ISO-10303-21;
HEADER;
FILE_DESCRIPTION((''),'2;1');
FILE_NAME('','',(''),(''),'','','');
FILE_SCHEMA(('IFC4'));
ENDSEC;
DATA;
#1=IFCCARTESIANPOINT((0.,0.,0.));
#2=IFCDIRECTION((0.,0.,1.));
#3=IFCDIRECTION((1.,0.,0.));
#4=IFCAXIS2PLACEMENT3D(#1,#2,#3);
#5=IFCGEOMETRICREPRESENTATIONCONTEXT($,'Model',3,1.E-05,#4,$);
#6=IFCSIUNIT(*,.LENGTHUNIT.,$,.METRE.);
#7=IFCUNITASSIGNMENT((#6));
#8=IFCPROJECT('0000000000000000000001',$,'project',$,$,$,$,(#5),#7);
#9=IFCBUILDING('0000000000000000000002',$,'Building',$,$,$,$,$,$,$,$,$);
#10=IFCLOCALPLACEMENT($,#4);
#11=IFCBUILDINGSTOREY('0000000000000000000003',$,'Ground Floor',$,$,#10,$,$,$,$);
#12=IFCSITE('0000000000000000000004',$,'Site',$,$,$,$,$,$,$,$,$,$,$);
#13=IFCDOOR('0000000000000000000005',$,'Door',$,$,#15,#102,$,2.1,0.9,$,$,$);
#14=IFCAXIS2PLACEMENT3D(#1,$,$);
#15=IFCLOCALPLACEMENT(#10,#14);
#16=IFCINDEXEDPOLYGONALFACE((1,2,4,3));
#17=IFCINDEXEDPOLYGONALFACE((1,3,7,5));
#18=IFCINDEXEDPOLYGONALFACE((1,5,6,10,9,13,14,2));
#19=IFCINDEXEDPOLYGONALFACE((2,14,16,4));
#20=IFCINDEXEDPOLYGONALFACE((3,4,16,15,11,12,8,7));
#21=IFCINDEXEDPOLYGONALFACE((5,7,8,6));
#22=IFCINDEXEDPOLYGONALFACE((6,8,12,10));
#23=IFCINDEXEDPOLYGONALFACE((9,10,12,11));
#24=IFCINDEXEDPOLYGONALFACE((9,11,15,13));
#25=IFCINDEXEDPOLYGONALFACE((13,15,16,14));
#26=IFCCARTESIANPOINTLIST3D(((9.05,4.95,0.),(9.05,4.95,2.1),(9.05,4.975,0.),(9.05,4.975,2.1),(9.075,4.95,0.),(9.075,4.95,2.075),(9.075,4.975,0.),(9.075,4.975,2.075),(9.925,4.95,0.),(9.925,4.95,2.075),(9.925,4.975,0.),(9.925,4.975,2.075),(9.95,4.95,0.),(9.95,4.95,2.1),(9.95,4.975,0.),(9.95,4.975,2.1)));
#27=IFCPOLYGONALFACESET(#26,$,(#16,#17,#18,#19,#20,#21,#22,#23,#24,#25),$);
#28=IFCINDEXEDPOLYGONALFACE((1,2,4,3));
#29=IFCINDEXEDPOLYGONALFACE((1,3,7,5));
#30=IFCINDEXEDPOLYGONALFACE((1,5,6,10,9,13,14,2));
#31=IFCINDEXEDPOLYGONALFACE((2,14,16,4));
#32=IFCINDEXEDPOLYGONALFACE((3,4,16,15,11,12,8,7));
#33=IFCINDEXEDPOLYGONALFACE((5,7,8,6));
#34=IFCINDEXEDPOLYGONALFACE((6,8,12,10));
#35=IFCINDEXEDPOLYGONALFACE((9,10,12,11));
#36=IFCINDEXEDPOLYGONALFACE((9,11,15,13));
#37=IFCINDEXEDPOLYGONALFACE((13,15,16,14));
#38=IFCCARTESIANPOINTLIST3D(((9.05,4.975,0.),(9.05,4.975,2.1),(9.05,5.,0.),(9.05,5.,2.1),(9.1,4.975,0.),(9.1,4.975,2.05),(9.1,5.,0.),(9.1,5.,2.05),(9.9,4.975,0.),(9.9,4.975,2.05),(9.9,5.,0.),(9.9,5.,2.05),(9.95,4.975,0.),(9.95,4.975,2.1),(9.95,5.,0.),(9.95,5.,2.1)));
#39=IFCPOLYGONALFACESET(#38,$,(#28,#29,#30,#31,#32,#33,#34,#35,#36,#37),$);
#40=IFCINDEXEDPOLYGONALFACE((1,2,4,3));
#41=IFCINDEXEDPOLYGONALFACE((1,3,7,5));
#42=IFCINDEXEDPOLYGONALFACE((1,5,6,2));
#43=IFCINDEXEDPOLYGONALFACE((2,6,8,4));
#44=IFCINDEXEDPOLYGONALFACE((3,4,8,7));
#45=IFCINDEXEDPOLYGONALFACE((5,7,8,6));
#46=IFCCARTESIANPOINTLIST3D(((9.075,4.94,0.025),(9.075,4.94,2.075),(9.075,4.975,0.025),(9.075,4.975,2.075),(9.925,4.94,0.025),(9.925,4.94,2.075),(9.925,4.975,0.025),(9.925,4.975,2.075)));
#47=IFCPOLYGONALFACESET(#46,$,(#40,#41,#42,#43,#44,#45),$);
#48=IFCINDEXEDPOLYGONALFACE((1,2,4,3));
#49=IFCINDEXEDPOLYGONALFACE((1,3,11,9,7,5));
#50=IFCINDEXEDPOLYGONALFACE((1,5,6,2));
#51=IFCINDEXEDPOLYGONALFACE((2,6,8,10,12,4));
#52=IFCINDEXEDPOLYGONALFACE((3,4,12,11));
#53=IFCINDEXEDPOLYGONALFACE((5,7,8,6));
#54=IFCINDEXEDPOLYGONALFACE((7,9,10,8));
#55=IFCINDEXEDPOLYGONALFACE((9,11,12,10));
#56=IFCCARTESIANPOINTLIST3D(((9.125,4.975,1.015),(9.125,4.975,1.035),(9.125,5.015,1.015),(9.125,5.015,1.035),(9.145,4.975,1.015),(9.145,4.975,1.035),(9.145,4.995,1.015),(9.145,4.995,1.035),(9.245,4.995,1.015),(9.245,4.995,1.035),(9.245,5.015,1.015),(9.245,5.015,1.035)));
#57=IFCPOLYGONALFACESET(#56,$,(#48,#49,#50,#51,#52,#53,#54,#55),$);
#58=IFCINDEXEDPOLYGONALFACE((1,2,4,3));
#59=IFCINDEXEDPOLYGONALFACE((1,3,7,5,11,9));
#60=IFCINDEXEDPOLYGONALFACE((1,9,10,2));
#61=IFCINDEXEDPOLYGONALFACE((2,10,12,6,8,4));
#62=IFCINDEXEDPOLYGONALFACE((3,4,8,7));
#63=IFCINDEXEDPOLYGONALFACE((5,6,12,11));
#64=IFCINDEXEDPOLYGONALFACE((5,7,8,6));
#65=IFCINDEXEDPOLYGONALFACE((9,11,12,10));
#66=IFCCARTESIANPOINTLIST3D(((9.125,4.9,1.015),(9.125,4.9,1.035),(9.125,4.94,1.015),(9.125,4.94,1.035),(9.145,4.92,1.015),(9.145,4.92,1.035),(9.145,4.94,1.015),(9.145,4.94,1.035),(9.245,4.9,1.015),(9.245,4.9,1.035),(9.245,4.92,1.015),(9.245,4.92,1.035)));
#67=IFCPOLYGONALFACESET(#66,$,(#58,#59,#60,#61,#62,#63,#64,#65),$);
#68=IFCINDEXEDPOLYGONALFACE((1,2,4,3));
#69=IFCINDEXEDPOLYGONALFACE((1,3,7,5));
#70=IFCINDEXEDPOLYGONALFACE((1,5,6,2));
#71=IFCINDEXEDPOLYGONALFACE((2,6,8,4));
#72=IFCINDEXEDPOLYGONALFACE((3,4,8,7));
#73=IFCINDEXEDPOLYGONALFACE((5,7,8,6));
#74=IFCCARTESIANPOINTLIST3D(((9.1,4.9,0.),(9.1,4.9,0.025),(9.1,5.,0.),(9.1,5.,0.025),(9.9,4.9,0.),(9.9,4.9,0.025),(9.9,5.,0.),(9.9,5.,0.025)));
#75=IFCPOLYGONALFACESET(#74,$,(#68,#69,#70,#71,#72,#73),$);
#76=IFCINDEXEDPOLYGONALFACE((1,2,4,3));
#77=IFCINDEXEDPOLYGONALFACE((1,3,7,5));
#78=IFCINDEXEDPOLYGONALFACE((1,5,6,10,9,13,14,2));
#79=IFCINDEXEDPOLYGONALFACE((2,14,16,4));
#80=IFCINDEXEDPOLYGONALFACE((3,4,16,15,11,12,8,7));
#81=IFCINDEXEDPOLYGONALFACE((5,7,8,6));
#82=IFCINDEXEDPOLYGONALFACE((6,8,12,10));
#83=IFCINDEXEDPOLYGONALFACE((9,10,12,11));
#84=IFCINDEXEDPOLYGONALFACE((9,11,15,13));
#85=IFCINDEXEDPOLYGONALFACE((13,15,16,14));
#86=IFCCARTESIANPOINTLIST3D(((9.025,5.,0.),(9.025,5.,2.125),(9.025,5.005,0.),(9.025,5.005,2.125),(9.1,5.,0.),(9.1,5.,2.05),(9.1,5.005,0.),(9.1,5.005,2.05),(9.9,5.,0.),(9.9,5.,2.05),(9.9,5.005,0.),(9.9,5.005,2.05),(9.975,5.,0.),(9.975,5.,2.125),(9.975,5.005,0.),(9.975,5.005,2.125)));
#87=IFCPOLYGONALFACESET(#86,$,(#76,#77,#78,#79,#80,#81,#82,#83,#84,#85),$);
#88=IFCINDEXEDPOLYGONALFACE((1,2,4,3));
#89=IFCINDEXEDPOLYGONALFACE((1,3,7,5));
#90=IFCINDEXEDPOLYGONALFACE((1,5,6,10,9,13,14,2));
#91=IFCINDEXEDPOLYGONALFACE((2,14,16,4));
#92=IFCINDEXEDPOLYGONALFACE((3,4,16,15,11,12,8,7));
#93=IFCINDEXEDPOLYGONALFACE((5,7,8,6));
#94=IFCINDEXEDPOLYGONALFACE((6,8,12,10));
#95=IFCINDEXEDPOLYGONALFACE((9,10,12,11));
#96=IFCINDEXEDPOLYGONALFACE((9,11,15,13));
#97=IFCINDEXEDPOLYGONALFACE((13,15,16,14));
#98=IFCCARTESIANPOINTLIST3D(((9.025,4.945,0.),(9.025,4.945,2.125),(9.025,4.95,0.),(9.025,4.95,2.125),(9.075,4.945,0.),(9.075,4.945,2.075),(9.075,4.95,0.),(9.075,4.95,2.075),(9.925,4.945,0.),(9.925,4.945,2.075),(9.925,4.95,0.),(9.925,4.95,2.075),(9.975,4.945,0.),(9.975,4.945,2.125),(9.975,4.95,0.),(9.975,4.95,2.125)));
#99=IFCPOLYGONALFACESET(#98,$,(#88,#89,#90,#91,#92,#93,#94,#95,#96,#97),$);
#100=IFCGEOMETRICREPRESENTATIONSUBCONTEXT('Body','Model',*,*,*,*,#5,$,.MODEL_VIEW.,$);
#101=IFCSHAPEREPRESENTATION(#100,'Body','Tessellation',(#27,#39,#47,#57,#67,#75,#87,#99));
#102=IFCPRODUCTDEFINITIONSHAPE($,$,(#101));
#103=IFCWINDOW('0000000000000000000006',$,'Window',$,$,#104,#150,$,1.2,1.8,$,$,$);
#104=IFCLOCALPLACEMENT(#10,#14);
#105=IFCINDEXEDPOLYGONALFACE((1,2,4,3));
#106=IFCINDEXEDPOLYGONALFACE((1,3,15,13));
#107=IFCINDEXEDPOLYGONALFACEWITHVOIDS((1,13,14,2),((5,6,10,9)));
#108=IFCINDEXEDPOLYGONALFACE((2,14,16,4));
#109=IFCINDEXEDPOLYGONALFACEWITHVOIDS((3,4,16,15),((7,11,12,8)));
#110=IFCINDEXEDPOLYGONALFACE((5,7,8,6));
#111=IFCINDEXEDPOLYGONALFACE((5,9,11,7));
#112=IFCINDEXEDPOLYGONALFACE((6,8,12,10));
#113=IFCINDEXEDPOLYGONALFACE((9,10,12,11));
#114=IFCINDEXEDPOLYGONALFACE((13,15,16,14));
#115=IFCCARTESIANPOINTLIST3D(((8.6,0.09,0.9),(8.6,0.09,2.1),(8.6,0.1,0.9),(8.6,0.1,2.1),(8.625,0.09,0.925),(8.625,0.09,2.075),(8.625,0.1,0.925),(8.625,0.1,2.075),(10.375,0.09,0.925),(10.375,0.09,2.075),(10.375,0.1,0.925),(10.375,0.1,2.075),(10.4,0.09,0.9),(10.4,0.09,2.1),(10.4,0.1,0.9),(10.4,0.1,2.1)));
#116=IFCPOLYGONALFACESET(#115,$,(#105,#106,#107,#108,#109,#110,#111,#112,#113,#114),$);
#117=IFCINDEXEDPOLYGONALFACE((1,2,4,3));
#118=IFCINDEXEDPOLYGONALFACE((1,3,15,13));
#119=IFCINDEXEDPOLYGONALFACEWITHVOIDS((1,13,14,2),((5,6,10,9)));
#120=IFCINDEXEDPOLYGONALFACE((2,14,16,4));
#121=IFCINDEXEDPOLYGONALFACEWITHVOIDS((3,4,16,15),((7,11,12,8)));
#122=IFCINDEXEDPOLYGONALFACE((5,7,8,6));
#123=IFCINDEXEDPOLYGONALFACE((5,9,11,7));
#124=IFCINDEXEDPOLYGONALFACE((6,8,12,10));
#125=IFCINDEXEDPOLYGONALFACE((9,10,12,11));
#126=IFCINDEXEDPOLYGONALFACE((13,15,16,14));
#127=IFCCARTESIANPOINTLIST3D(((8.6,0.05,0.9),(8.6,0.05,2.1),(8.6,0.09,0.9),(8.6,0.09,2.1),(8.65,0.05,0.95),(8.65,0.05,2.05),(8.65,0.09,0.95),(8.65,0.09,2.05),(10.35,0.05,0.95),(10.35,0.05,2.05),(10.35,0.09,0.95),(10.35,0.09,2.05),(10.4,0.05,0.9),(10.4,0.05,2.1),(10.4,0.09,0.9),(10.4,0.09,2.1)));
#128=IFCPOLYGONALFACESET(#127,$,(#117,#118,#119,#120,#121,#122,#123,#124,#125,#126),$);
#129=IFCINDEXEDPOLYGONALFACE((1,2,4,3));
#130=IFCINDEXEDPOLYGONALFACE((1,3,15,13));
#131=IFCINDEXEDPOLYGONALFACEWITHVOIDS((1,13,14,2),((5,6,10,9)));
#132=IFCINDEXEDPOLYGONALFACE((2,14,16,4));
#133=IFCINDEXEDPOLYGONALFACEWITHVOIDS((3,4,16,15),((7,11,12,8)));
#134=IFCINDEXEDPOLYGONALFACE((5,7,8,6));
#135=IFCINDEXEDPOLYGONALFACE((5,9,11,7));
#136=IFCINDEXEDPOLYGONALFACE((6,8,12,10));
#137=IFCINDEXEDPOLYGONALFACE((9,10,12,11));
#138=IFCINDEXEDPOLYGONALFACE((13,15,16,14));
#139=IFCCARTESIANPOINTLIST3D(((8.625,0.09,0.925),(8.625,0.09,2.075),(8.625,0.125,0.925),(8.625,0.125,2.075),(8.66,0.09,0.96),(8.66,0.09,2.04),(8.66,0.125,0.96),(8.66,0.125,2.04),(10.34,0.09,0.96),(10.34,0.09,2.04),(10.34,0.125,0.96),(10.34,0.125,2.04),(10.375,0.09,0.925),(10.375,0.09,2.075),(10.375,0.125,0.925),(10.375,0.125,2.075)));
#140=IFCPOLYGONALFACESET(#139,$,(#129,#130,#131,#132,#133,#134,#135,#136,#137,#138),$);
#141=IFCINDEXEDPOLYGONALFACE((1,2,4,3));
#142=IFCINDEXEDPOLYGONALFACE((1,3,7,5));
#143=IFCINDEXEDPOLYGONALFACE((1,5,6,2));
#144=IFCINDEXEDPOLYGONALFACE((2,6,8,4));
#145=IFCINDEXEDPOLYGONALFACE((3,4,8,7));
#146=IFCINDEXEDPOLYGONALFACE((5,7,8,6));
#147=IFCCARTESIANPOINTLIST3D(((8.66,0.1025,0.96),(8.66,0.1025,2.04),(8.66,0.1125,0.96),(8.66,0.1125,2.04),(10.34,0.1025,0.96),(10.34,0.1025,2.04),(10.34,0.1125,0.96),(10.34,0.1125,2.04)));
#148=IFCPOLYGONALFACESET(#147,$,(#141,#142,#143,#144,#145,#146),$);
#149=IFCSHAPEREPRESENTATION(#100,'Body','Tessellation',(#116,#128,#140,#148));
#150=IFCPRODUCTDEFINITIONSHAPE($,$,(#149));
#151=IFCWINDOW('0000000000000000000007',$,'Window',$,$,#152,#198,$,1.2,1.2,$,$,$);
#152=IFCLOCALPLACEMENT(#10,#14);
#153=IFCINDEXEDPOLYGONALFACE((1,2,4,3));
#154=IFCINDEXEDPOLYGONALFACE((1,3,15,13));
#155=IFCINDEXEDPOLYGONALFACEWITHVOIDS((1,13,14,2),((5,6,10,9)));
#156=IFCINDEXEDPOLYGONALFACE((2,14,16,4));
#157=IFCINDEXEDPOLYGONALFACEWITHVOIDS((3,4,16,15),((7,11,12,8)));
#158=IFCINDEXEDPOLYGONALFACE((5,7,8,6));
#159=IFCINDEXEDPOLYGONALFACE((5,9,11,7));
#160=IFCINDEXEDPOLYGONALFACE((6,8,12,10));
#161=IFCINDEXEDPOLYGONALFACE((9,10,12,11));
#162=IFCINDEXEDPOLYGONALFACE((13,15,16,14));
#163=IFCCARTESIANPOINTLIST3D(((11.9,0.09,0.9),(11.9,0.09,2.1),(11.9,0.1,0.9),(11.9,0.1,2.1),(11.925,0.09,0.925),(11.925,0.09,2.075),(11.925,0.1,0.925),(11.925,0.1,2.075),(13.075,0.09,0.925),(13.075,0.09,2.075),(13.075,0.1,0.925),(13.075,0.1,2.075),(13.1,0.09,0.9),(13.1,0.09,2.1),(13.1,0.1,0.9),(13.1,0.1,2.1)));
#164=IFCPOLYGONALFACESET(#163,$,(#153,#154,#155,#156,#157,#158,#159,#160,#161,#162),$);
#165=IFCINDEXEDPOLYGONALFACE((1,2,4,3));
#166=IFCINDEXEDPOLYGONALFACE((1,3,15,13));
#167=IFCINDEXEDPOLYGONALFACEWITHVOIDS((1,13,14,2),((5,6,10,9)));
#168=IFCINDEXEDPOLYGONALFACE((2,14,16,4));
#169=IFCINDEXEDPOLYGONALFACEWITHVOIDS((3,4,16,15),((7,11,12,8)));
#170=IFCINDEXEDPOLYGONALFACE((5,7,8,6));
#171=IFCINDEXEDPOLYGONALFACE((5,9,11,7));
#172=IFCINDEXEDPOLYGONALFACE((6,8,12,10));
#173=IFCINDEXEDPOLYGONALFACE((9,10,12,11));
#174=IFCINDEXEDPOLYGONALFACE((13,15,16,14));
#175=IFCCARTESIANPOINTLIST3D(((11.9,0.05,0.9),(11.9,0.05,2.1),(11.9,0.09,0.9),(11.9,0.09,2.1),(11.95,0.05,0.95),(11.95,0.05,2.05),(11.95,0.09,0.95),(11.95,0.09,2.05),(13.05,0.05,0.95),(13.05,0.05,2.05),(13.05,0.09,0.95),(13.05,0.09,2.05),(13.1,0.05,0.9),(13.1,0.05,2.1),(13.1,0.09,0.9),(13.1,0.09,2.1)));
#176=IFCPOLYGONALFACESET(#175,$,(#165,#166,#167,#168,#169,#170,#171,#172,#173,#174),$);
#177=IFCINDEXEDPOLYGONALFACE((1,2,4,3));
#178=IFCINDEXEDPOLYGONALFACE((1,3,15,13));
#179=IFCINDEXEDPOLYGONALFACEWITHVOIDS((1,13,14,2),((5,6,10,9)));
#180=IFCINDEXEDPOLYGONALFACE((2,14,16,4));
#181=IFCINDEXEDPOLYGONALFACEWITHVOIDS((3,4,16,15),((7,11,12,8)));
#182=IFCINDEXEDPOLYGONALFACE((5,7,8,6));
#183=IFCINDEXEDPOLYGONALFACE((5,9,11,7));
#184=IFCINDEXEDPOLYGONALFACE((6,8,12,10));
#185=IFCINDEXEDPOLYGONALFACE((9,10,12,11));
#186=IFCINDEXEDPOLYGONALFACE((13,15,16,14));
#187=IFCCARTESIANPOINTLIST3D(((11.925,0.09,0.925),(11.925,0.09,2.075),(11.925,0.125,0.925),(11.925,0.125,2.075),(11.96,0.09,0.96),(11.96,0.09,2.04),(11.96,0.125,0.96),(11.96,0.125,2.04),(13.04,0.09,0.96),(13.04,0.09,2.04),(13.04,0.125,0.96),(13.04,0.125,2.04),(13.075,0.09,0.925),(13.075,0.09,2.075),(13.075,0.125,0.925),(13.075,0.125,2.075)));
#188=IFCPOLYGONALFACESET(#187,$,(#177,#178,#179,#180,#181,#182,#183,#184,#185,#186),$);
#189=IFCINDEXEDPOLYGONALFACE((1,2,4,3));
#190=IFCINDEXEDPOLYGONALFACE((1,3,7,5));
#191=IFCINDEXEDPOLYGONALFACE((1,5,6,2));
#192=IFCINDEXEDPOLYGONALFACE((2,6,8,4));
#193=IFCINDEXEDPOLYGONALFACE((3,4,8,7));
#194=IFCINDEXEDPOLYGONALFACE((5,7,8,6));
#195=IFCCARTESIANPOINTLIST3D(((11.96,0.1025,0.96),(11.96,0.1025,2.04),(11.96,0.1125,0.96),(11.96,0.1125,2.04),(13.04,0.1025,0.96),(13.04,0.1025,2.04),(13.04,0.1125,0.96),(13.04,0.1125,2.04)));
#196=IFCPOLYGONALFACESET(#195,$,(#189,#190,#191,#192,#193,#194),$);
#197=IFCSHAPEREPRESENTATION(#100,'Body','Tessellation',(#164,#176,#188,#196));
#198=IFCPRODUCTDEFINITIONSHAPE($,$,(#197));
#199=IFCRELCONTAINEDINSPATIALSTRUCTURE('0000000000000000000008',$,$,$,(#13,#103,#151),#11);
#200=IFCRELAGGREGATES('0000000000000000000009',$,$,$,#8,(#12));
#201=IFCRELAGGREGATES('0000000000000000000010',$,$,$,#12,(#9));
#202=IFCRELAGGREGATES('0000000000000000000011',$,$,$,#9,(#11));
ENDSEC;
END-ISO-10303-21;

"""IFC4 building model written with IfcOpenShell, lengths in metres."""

from ifc_helpers import new_model, si_unit, frame, origin_with_axes, place, context, subcontext, project, spatial, line, indexed_curve, outline, extrude, element, save


model = new_model("IFC4")

# Units and contexts
model_context = context("Model", 3, precision=1e-05, world=origin_with_axes())
body_context = subcontext(model_context, "Body", "Model", "MODEL_VIEW")
ifc_project = project(units=[si_unit("LENGTHUNIT", "METRE")], contexts=[model_context])

# Site, building, storey
site = spatial("IfcSite", under=ifc_project, Name="Site")
building = spatial("IfcBuilding", under=site, Name="Building")
storey_placement = place(None, origin_with_axes())
storey = spatial("IfcBuildingStorey", under=building, at=storey_placement, Name="Ground Floor")

# Door
door_1_placement = place(storey_placement, frame((9.95, 5.0, 0.0), z_axis=(0.0, 0.0, 1.0), x_axis=(-1.0, 0.0, 0.0)))
element("IfcDoor", 1, at=door_1_placement, inside=storey, Name="Door", OverallHeight=2.1, OverallWidth=0.9, context=body_context, shape_type="SweptSolid", body=[
    extrude(outline(indexed_curve([(0.0, 0.0), (0.0, 2.1), (0.9, 2.1), (0.9, 0.0), (0.875, 0.0), (0.875, 2.075), (0.025, 2.075), (0.025, 0.0)], segments=[line(1, 2, 3, 4, 5, 6, 7, 8, 1)])), frame((0.0, 0.025, 0.0), z_axis=(0.0, -1.0, 0.0), x_axis=(1.0, 0.0, 0.0)), (0.0, 0.0, -1.0), 0.025),
    extrude(outline(indexed_curve([(0.0, 0.0), (0.0, 2.1), (0.9, 2.1), (0.9, 0.0), (0.85, 0.0), (0.85, 2.05), (0.05, 2.05), (0.05, 0.0)], segments=[line(1, 2, 3, 4, 5, 6, 7, 8, 1)])), frame((0.0, 0.0, 0.0), z_axis=(0.0, -1.0, 0.0), x_axis=(1.0, 0.0, 0.0)), (0.0, 0.0, -1.0), 0.025),
    extrude(outline(indexed_curve([(0.0, 0.0), (0.85, 0.0), (0.85, 0.035), (0.0, 0.035)], segments=[line(1, 2, 3, 4, 1)])), frame((0.025, 0.025, 0.025), z_axis=(0.0, 0.0, 1.0), x_axis=(1.0, 0.0, 0.0)), (0.0, 0.0, 1.0), 2.05),
    extrude(outline(indexed_curve([(0.0, 0.0), (0.0, -0.04), (-0.12, -0.04), (-0.12, -0.02), (-0.02, -0.02), (-0.02, 0.0)], segments=[line(1, 2, 3, 4, 5, 6, 1)])), frame((0.825, 0.025, 1.015), z_axis=(0.0, 0.0, 1.0), x_axis=(1.0, 0.0, 0.0)), (0.0, 0.0, 1.0), 0.02),
    extrude(outline(indexed_curve([(0.0, 0.0), (0.0, 0.04), (-0.12, 0.04), (-0.12, 0.02), (-0.02, 0.02), (-0.02, 0.0)], segments=[line(1, 2, 3, 4, 5, 6, 1)])), frame((0.825, 0.06, 1.015), z_axis=(0.0, 0.0, 1.0), x_axis=(1.0, 0.0, 0.0)), (0.0, 0.0, 1.0), 0.02),
    extrude(outline(indexed_curve([(0.0, 0.0), (0.8, 0.0), (0.8, 0.1), (0.0, 0.1)], segments=[line(1, 2, 3, 4, 1)])), frame((0.05, 0.0, 0.0), z_axis=(0.0, 0.0, 1.0), x_axis=(1.0, 0.0, 0.0)), (0.0, 0.0, 1.0), 0.025),
    extrude(outline(indexed_curve([(0.0, 0.0), (0.0, 2.125), (0.95, 2.125), (0.95, 0.0), (0.875, 0.0), (0.875, 2.05), (0.075, 2.05), (0.075, 0.0)], segments=[line(1, 2, 3, 4, 5, 6, 7, 8, 1)])), frame((-0.025, -0.005, 0.0), z_axis=(0.0, -1.0, 0.0), x_axis=(1.0, 0.0, 0.0)), (0.0, 0.0, -1.0), 0.005),
    extrude(outline(indexed_curve([(0.0, 0.0), (0.0, 2.125), (0.95, 2.125), (0.95, 0.0), (0.9, 0.0), (0.9, 2.075), (0.05, 2.075), (0.05, 0.0)], segments=[line(1, 2, 3, 4, 5, 6, 7, 8, 1)])), frame((-0.025, 0.05, 0.0), z_axis=(0.0, -1.0, 0.0), x_axis=(1.0, 0.0, 0.0)), (0.0, 0.0, -1.0), 0.005),
])

# Windows
window_1_placement = place(storey_placement, frame((8.6, 0.0, 0.9), z_axis=(0.0, 0.0, 1.0), x_axis=(1.0, 0.0, 0.0)))
element("IfcWindow", 2, at=window_1_placement, inside=storey, Name="Window", OverallHeight=1.2, OverallWidth=1.8, context=body_context, shape_type="SweptSolid", body=[
    extrude(outline(indexed_curve([(0.0, 0.0), (1.8, 0.0), (1.8, 1.2), (0.0, 1.2)], segments=[line(1, 2, 3, 4, 1)]), holes=[indexed_curve([(0.025, 0.025), (1.775, 0.025), (1.775, 1.175), (0.025, 1.175)], segments=[line(1, 2, 3, 4, 1)])]), frame((0.0, 0.09, 0.0), z_axis=(0.0, -1.0, 0.0), x_axis=(1.0, 0.0, 0.0)), (0.0, 0.0, -1.0), 0.01),
    extrude(outline(indexed_curve([(0.0, 0.0), (1.8, 0.0), (1.8, 1.2), (0.0, 1.2)], segments=[line(1, 2, 3, 4, 1)]), holes=[indexed_curve([(0.05, 0.05), (1.75, 0.05), (1.75, 1.15), (0.05, 1.15)], segments=[line(1, 2, 3, 4, 1)])]), frame((0.0, 0.05, 0.0), z_axis=(0.0, -1.0, 0.0), x_axis=(1.0, 0.0, 0.0)), (0.0, 0.0, -1.0), 0.04),
    extrude(outline(indexed_curve([(0.0, 0.0), (1.75, 0.0), (1.75, 1.15), (0.0, 1.15)], segments=[line(1, 2, 3, 4, 1)]), holes=[indexed_curve([(0.035, 0.035), (1.715, 0.035), (1.715, 1.115), (0.035, 1.115)], segments=[line(1, 2, 3, 4, 1)])]), frame((0.025, 0.09, 0.025), z_axis=(0.0, -1.0, 0.0), x_axis=(1.0, 0.0, 0.0)), (0.0, 0.0, -1.0), 0.035),
    extrude(outline(indexed_curve([(0.035, 0.035), (1.715, 0.035), (1.715, 1.115), (0.035, 1.115)], segments=[line(1, 2, 3, 4, 1)])), frame((0.025, 0.1025, 0.025), z_axis=(0.0, -1.0, 0.0), x_axis=(1.0, 0.0, 0.0)), (0.0, 0.0, -1.0), 0.01),
])
window_2_placement = place(storey_placement, frame((11.9, 0.0, 0.9), z_axis=(0.0, 0.0, 1.0), x_axis=(1.0, 0.0, 0.0)))
element("IfcWindow", 3, at=window_2_placement, inside=storey, Name="Window", OverallHeight=1.2, OverallWidth=1.2, context=body_context, shape_type="SweptSolid", body=[
    extrude(outline(indexed_curve([(0.0, 0.0), (1.2, 0.0), (1.2, 1.2), (0.0, 1.2)], segments=[line(1, 2, 3, 4, 1)]), holes=[indexed_curve([(0.025, 0.025), (1.175, 0.025), (1.175, 1.175), (0.025, 1.175)], segments=[line(1, 2, 3, 4, 1)])]), frame((0.0, 0.09, 0.0), z_axis=(0.0, -1.0, 0.0), x_axis=(1.0, 0.0, 0.0)), (0.0, 0.0, -1.0), 0.01),
    extrude(outline(indexed_curve([(0.0, 0.0), (1.2, 0.0), (1.2, 1.2), (0.0, 1.2)], segments=[line(1, 2, 3, 4, 1)]), holes=[indexed_curve([(0.05, 0.05), (1.15, 0.05), (1.15, 1.15), (0.05, 1.15)], segments=[line(1, 2, 3, 4, 1)])]), frame((0.0, 0.05, 0.0), z_axis=(0.0, -1.0, 0.0), x_axis=(1.0, 0.0, 0.0)), (0.0, 0.0, -1.0), 0.04),
    extrude(outline(indexed_curve([(0.0, 0.0), (1.15, 0.0), (1.15, 1.15), (0.0, 1.15)], segments=[line(1, 2, 3, 4, 1)]), holes=[indexed_curve([(0.035, 0.035), (1.115, 0.035), (1.115, 1.115), (0.035, 1.115)], segments=[line(1, 2, 3, 4, 1)])]), frame((0.025, 0.09, 0.025), z_axis=(0.0, -1.0, 0.0), x_axis=(1.0, 0.0, 0.0)), (0.0, 0.0, -1.0), 0.035),
    extrude(outline(indexed_curve([(0.035, 0.035), (1.115, 0.035), (1.115, 1.115), (0.035, 1.115)], segments=[line(1, 2, 3, 4, 1)])), frame((0.025, 0.1025, 0.025), z_axis=(0.0, -1.0, 0.0), x_axis=(1.0, 0.0, 0.0)), (0.0, 0.0, -1.0), 0.01),
])

save(model, "model.ifc")
